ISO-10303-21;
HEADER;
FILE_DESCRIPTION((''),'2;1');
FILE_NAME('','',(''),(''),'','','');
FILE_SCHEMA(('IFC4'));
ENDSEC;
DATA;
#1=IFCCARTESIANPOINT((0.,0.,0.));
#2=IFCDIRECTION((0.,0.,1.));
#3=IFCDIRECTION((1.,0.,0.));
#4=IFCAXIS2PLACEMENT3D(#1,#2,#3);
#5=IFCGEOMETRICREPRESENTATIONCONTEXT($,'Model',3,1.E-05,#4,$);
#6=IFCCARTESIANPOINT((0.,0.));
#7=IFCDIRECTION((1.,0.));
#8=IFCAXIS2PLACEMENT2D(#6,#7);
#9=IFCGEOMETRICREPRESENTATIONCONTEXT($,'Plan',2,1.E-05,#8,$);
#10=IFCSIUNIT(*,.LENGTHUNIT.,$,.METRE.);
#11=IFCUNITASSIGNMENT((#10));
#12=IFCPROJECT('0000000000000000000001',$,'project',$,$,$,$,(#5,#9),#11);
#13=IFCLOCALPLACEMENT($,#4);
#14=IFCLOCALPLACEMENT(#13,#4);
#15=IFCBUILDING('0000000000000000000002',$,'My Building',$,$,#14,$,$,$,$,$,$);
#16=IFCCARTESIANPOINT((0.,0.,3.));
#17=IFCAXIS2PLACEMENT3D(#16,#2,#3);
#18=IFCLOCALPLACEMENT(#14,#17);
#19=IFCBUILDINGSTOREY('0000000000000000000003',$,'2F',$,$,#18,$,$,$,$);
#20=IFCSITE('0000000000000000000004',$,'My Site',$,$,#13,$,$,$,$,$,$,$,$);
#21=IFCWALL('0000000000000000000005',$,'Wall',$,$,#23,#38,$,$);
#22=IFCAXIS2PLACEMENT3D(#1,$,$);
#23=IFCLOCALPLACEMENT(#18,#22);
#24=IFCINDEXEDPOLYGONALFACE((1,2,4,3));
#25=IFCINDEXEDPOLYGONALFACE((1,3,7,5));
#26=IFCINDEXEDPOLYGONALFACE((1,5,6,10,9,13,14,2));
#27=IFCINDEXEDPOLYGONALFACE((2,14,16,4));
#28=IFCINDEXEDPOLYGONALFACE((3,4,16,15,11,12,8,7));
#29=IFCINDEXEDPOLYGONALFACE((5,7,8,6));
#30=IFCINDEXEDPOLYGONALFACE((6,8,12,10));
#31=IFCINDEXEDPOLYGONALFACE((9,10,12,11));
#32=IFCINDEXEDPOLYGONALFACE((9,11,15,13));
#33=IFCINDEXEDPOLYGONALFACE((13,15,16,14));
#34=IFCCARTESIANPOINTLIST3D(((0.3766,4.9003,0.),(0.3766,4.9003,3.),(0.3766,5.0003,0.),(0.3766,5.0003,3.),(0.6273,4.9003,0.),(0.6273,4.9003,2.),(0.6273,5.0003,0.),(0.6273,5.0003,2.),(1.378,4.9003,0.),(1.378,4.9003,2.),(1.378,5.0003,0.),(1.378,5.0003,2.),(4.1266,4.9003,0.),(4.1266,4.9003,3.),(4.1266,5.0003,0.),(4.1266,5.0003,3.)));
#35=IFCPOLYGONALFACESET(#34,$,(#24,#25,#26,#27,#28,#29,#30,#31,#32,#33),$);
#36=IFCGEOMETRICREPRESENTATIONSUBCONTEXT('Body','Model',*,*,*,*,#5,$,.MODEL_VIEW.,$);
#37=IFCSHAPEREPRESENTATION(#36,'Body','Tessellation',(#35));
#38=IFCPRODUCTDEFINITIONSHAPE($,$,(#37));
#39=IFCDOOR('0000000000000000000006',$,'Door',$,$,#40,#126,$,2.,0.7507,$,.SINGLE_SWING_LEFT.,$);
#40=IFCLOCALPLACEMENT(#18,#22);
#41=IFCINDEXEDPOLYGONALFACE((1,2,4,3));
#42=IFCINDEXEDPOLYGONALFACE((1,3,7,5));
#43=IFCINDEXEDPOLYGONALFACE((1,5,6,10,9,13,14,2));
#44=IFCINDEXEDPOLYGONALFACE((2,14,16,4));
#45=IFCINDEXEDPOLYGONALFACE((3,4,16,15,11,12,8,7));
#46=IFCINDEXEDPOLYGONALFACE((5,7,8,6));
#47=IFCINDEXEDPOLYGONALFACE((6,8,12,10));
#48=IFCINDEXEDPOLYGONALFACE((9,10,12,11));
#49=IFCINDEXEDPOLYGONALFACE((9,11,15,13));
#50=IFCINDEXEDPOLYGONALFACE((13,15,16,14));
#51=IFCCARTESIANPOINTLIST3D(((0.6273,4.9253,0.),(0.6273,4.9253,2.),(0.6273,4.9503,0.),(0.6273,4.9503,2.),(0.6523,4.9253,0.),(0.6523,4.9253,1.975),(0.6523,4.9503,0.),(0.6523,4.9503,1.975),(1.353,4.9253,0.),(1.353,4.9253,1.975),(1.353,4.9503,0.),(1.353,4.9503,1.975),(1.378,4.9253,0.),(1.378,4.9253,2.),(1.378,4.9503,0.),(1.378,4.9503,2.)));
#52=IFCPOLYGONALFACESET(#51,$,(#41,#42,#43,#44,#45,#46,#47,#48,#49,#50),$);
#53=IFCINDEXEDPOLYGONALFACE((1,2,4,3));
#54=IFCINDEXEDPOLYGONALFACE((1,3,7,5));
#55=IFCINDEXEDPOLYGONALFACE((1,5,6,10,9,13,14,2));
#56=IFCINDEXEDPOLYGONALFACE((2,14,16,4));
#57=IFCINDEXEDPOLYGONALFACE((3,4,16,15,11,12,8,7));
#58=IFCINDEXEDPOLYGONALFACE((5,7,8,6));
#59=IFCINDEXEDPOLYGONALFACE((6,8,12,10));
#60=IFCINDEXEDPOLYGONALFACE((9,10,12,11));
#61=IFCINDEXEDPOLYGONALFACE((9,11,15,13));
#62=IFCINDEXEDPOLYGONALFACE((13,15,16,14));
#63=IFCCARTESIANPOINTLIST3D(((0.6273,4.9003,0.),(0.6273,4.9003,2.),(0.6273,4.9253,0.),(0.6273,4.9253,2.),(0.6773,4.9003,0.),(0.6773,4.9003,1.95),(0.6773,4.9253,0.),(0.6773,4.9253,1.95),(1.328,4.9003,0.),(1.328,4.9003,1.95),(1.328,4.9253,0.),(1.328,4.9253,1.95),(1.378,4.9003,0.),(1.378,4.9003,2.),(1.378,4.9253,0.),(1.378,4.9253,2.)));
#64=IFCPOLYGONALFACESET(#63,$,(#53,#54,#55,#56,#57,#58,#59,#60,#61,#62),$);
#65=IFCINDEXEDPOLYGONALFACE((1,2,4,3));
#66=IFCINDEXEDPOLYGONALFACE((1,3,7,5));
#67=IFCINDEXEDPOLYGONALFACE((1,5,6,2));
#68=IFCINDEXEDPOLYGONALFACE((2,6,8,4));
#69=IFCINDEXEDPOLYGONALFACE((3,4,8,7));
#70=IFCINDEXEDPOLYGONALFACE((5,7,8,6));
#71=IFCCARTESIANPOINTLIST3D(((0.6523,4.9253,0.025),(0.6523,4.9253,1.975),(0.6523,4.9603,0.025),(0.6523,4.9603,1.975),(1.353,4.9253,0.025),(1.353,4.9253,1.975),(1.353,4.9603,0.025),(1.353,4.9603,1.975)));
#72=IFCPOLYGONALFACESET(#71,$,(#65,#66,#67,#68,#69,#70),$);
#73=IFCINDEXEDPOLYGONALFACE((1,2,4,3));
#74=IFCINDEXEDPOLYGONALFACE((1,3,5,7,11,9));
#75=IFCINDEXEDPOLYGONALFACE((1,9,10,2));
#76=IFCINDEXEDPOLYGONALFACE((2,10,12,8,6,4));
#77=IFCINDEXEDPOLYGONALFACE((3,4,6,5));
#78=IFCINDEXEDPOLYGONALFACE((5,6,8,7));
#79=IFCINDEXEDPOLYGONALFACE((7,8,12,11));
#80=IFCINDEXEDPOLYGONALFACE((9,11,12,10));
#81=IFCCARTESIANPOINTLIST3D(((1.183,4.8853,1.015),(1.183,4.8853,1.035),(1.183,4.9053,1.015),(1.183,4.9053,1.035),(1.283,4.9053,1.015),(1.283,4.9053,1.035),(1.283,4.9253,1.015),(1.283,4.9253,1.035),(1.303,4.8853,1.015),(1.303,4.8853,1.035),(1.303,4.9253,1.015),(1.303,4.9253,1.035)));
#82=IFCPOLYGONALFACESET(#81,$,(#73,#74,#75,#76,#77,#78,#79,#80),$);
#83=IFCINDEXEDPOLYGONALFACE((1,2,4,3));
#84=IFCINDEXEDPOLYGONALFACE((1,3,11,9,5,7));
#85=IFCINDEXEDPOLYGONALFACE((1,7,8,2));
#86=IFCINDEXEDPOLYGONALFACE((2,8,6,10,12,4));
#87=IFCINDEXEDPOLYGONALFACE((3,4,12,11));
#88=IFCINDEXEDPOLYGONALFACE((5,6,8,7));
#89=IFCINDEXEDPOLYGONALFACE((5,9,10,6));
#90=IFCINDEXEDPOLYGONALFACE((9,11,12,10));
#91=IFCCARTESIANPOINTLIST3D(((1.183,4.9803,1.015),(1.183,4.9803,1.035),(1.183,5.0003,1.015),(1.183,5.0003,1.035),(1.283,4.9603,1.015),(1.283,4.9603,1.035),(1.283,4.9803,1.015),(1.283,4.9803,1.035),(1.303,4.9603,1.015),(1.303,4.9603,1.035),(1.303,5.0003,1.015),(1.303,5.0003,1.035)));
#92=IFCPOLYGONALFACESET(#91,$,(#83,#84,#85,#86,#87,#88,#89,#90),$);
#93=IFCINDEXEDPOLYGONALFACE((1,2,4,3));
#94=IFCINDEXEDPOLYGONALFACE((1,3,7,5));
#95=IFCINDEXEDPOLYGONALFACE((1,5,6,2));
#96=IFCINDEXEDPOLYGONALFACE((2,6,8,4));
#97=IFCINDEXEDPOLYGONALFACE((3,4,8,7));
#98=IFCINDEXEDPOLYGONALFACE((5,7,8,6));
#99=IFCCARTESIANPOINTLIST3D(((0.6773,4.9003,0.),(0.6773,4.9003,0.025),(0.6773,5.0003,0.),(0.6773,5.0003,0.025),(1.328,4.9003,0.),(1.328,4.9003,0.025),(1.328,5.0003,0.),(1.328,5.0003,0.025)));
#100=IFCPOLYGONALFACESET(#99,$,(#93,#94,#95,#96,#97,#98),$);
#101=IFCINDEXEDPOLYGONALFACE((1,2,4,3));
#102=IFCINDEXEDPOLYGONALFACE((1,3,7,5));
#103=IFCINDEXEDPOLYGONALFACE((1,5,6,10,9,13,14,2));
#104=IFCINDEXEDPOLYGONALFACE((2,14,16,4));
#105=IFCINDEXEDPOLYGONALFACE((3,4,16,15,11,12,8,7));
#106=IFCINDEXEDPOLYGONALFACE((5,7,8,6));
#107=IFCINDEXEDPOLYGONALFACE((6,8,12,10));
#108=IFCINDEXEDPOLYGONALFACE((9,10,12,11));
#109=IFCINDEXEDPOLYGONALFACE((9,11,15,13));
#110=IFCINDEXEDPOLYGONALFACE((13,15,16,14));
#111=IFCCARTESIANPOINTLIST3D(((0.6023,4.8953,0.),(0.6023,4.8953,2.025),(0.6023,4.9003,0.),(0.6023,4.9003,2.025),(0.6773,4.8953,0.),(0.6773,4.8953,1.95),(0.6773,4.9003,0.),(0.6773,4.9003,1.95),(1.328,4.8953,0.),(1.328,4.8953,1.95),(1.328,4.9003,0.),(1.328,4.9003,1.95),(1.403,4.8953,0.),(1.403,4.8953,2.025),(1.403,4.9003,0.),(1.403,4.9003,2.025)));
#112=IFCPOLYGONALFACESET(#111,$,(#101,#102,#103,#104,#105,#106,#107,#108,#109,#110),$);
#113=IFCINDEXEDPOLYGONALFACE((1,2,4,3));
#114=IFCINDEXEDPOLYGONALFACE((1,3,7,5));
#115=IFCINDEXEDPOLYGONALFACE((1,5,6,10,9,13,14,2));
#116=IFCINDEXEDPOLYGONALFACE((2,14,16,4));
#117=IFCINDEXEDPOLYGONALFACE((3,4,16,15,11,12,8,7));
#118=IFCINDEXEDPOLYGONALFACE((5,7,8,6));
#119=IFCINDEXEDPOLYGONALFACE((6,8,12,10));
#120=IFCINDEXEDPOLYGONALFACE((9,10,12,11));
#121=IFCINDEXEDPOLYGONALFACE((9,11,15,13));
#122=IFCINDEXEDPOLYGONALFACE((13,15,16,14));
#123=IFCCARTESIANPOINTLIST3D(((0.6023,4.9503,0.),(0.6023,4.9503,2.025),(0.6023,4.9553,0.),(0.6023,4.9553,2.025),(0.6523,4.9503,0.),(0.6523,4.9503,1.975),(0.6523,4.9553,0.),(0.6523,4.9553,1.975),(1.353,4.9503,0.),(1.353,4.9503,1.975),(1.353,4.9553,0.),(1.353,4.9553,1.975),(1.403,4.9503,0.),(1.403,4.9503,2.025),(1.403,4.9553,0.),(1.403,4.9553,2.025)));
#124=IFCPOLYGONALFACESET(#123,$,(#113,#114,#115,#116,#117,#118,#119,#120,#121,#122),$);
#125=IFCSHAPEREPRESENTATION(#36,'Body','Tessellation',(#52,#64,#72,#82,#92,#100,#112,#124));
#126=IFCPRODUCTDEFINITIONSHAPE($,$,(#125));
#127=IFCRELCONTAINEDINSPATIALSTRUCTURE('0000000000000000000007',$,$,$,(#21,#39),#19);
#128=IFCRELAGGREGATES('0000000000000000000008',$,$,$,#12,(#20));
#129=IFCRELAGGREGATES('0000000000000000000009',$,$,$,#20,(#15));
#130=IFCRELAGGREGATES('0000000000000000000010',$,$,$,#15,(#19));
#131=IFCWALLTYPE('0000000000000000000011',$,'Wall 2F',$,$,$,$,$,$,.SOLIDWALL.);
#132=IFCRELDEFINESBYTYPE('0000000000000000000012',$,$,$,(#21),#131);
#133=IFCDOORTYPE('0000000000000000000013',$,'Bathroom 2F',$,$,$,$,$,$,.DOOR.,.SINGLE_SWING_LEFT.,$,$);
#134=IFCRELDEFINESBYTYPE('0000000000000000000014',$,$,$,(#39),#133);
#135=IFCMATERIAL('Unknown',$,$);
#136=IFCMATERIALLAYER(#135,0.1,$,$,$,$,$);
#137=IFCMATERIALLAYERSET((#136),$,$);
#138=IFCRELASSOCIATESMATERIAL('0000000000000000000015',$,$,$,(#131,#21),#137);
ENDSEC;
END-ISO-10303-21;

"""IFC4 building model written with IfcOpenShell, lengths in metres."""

from ifc_helpers import new_model, entity, si_unit, frame, origin_with_axes, origin_2d_with_axis, place, context, subcontext, project, spatial, line, indexed_curve, outline, extrude, shape, source, transform, mapped, material, layer, layer_set, layer_usage, type_object, type_shapes, element, fill, save


model = new_model("IFC4")

# Units and contexts
model_context = context("Model", 3, precision=1e-05, world=origin_with_axes())
plan_context = context("Plan", 2, precision=1e-05, world=origin_2d_with_axis())
body_context_1 = subcontext(model_context, "Body", "Model", "MODEL_VIEW")
body_context_2 = subcontext(plan_context, "Body", "Plan", "PLAN_VIEW")
ifc_project = project(units=[si_unit("LENGTHUNIT", "METRE")], contexts=[model_context, plan_context])

# Site, building, storey
site_placement = place(None, origin_with_axes())
site = spatial("IfcSite", under=ifc_project, at=site_placement, Name="My Site")
building_placement = place(site_placement, origin_with_axes())
building = spatial("IfcBuilding", under=site, at=building_placement, Name="My Building")
storey_placement = place(building_placement, frame((0.0, 0.0, 3.0), z_axis=(0.0, 0.0, 1.0), x_axis=(1.0, 0.0, 0.0)))
storey = spatial("IfcBuildingStorey", under=building, at=storey_placement, Name="2F")

# Shared definitions
ifc_material = material(Name="Unknown")

# Shared definitions
ifc_layer_1 = layer(ifc_material, 0.1)
ifc_layer_set_1 = layer_set([ifc_layer_1])
wall_type = type_object("IfcWallType", Name="Wall 2F", PredefinedType="SOLIDWALL", material=ifc_layer_set_1)

# Wall, opening, door
ifc_layer_usage_1 = layer_usage(ifc_layer_set_1, "AXIS2", "POSITIVE", 0.0)
wall_1_placement = place(storey_placement, frame((4.2266, 5.0003, 0.0), z_axis=(0.0, 0.0, 1.0), x_axis=(-1.0, 0.0, 0.0)))
wall_1 = element("IfcWall", 1, at=wall_1_placement, inside=storey, type_object=wall_type, material=ifc_layer_usage_1, Name="Wall", context=body_context_1, shape_type="SweptSolid", body=[
    extrude(outline(indexed_curve([(0.1, 0.0), (0.1, 0.1), (3.85, 0.1), (3.85, 0.0)], segments=[line(1, 2, 3, 4, 1)])), origin_with_axes(), (0.0, 0.0, 1.0), 3.0),
])
shared_shape_1 = source(origin_with_axes(), body_context_1, "Body", "SweptSolid", [
    extrude(outline(indexed_curve([(0.0, 0.0), (0.7507, 0.0), (0.7507, 2.0), (0.0, 2.0)], segments=[line(1, 2, 3, 4, 1)])), frame((0.0, -0.6, 0.0), z_axis=(0.0, -1.0, 0.0), x_axis=(1.0, 0.0, 0.0)), (0.0, 0.0, -1.0), 1.2),
])
opening_1_placement = place(wall_1_placement, frame((3.5993, 0.1, 0.0), z_axis=(0.0, 0.0, 1.0), x_axis=(-1.0, 0.000001, 0.0)))
opening_1 = element("IfcOpeningElement", 2, at=opening_1_placement, cuts=wall_1, PredefinedType="OPENING", context=body_context_1, shape_type="MappedRepresentation", body=[
    mapped(shared_shape_1, transform((0.0, 0.0, 0.0), x_axis=(1.0, 0.0, 0.0), y_axis=(0.0, 1.0, 0.0), z_axis=(0.0, 0.0, 1.0), scale=1.0)),
])
door_type_1 = type_object("IfcDoorType", Name="Bathroom 2F", OperationType="SINGLE_SWING_LEFT", PredefinedType="DOOR")
shared_shape_2 = source(origin_with_axes(), body_context_1, "Body", "SweptSolid", [
    extrude(outline(indexed_curve([(0.0, 0.0), (0.0, 2.0), (0.7507, 2.0), (0.7507, 0.0), (0.7257, 0.0), (0.7257, 1.975), (0.025, 1.975), (0.025, 0.0)], segments=[line(1, 2, 3, 4, 5, 6, 7, 8, 1)])), frame((0.0, 0.025, 0.0), z_axis=(0.0, -1.0, 0.0), x_axis=(1.0, 0.0, 0.0)), (0.0, 0.0, -1.0), 0.025),
    extrude(outline(indexed_curve([(0.0, 0.0), (0.0, 2.0), (0.7507, 2.0), (0.7507, 0.0), (0.7007, 0.0), (0.7007, 1.95), (0.05, 1.95), (0.05, 0.0)], segments=[line(1, 2, 3, 4, 5, 6, 7, 8, 1)])), frame((0.0, 0.0, 0.0), z_axis=(0.0, -1.0, 0.0), x_axis=(1.0, 0.0, 0.0)), (0.0, 0.0, -1.0), 0.025),
    extrude(outline(indexed_curve([(0.0, 0.0), (0.7007, 0.0), (0.7007, 0.035), (0.0, 0.035)], segments=[line(1, 2, 3, 4, 1)])), frame((0.025, 0.025, 0.025), z_axis=(0.0, 0.0, 1.0), x_axis=(1.0, 0.0, 0.0)), (0.0, 0.0, 1.0), 1.95),
    extrude(outline(indexed_curve([(0.0, 0.0), (0.0, -0.04), (-0.12, -0.04), (-0.12, -0.02), (-0.02, -0.02), (-0.02, 0.0)], segments=[line(1, 2, 3, 4, 5, 6, 1)])), frame((0.6757, 0.025, 1.015), z_axis=(0.0, 0.0, 1.0), x_axis=(1.0, 0.0, 0.0)), (0.0, 0.0, 1.0), 0.02),
    extrude(outline(indexed_curve([(0.0, 0.0), (0.0, 0.04), (-0.12, 0.04), (-0.12, 0.02), (-0.02, 0.02), (-0.02, 0.0)], segments=[line(1, 2, 3, 4, 5, 6, 1)])), frame((0.6757, 0.06, 1.015), z_axis=(0.0, 0.0, 1.0), x_axis=(1.0, 0.0, 0.0)), (0.0, 0.0, 1.0), 0.02),
    extrude(outline(indexed_curve([(0.0, 0.0), (0.6507, 0.0), (0.6507, 0.1), (0.0, 0.1)], segments=[line(1, 2, 3, 4, 1)])), frame((0.05, 0.0, 0.0), z_axis=(0.0, 0.0, 1.0), x_axis=(1.0, 0.0, 0.0)), (0.0, 0.0, 1.0), 0.025),
    extrude(outline(indexed_curve([(0.0, 0.0), (0.0, 2.025), (0.8007, 2.025), (0.8007, 0.0), (0.7257, 0.0), (0.7257, 1.95), (0.075, 1.95), (0.075, 0.0)], segments=[line(1, 2, 3, 4, 5, 6, 7, 8, 1)])), frame((-0.025, -0.005, 0.0), z_axis=(0.0, -1.0, 0.0), x_axis=(1.0, 0.0, 0.0)), (0.0, 0.0, -1.0), 0.005),
    extrude(outline(indexed_curve([(0.0, 0.0), (0.0, 2.025), (0.8007, 2.025), (0.8007, 0.0), (0.7507, 0.0), (0.7507, 1.975), (0.05, 1.975), (0.05, 0.0)], segments=[line(1, 2, 3, 4, 5, 6, 7, 8, 1)])), frame((-0.025, 0.05, 0.0), z_axis=(0.0, -1.0, 0.0), x_axis=(1.0, 0.0, 0.0)), (0.0, 0.0, -1.0), 0.005),
])
shared_shape_3 = source(origin_with_axes(), body_context_2, "Body", "Curve2D", [
    entity("IfcIndexedPolyCurve", entity("IfcCartesianPointList2D", [[0.0, 0.0], [0.0, 0.05], [0.025, 0.05], [0.025, 0.025], [0.05, 0.025], [0.05, 0.0]]), [entity("IfcLineIndex", [1, 2, 3, 4, 5, 6, 1])]),
    entity("IfcIndexedPolyCurve", entity("IfcCartesianPointList2D", [[0.7507, 0.0], [0.7507, 0.05], [0.7257, 0.05], [0.7257, 0.025], [0.7007, 0.025], [0.7007, 0.0]]), [entity("IfcLineIndex", [1, 2, 3, 4, 5, 6, 1])]),
    entity("IfcTrimmedCurve", entity("IfcEllipse", entity("IfcAxis2Placement2D", entity("IfcCartesianPoint", [0.06, 0.05]), entity("IfcDirection", [1.0, 0.0])), 0.6657, 0.7007), [entity("IfcCartesianPoint", [0.7257, 0.05])], [entity("IfcCartesianPoint", [0.06, 0.7507])], True, "CARTESIAN"),
    entity("IfcIndexedPolyCurve", entity("IfcCartesianPointList2D", [[0.025, 0.05], [0.06, 0.05], [0.06, 0.7507], [0.025, 0.7507]]), [entity("IfcLineIndex", [1, 2, 3, 4, 1])]),
])
type_shapes(door_type_1, [shared_shape_2, shared_shape_3])
door_1_placement = place(opening_1_placement, frame((0.0, 0.0, 0.0), z_axis=(0.0, 0.0, 1.0), x_axis=(1.0, 0.0, 0.0)))
door_1 = element("IfcDoor", 3, at=door_1_placement, inside=storey, type_object=door_type_1, Name="Door", OperationType="SINGLE_SWING_LEFT", OverallHeight=2.0, OverallWidth=0.7507, shapes=[
    shape(body_context_1, "Body", "MappedRepresentation", [mapped(shared_shape_2, transform((0.0, 0.0, 0.0), x_axis=(1.0, 0.0, 0.0), y_axis=(0.0, 1.0, 0.0), z_axis=(0.0, 0.0, 1.0), scale=1.0))]),
    shape(body_context_2, "Body", "MappedRepresentation", [mapped(shared_shape_3, transform((0.0, 0.0, 0.0), x_axis=(1.0, 0.0, 0.0), y_axis=(0.0, 1.0, 0.0), z_axis=(0.0, 0.0, 1.0), scale=1.0))]),
])
fill(opening_1, door_1)

save(model, "model.ifc")
